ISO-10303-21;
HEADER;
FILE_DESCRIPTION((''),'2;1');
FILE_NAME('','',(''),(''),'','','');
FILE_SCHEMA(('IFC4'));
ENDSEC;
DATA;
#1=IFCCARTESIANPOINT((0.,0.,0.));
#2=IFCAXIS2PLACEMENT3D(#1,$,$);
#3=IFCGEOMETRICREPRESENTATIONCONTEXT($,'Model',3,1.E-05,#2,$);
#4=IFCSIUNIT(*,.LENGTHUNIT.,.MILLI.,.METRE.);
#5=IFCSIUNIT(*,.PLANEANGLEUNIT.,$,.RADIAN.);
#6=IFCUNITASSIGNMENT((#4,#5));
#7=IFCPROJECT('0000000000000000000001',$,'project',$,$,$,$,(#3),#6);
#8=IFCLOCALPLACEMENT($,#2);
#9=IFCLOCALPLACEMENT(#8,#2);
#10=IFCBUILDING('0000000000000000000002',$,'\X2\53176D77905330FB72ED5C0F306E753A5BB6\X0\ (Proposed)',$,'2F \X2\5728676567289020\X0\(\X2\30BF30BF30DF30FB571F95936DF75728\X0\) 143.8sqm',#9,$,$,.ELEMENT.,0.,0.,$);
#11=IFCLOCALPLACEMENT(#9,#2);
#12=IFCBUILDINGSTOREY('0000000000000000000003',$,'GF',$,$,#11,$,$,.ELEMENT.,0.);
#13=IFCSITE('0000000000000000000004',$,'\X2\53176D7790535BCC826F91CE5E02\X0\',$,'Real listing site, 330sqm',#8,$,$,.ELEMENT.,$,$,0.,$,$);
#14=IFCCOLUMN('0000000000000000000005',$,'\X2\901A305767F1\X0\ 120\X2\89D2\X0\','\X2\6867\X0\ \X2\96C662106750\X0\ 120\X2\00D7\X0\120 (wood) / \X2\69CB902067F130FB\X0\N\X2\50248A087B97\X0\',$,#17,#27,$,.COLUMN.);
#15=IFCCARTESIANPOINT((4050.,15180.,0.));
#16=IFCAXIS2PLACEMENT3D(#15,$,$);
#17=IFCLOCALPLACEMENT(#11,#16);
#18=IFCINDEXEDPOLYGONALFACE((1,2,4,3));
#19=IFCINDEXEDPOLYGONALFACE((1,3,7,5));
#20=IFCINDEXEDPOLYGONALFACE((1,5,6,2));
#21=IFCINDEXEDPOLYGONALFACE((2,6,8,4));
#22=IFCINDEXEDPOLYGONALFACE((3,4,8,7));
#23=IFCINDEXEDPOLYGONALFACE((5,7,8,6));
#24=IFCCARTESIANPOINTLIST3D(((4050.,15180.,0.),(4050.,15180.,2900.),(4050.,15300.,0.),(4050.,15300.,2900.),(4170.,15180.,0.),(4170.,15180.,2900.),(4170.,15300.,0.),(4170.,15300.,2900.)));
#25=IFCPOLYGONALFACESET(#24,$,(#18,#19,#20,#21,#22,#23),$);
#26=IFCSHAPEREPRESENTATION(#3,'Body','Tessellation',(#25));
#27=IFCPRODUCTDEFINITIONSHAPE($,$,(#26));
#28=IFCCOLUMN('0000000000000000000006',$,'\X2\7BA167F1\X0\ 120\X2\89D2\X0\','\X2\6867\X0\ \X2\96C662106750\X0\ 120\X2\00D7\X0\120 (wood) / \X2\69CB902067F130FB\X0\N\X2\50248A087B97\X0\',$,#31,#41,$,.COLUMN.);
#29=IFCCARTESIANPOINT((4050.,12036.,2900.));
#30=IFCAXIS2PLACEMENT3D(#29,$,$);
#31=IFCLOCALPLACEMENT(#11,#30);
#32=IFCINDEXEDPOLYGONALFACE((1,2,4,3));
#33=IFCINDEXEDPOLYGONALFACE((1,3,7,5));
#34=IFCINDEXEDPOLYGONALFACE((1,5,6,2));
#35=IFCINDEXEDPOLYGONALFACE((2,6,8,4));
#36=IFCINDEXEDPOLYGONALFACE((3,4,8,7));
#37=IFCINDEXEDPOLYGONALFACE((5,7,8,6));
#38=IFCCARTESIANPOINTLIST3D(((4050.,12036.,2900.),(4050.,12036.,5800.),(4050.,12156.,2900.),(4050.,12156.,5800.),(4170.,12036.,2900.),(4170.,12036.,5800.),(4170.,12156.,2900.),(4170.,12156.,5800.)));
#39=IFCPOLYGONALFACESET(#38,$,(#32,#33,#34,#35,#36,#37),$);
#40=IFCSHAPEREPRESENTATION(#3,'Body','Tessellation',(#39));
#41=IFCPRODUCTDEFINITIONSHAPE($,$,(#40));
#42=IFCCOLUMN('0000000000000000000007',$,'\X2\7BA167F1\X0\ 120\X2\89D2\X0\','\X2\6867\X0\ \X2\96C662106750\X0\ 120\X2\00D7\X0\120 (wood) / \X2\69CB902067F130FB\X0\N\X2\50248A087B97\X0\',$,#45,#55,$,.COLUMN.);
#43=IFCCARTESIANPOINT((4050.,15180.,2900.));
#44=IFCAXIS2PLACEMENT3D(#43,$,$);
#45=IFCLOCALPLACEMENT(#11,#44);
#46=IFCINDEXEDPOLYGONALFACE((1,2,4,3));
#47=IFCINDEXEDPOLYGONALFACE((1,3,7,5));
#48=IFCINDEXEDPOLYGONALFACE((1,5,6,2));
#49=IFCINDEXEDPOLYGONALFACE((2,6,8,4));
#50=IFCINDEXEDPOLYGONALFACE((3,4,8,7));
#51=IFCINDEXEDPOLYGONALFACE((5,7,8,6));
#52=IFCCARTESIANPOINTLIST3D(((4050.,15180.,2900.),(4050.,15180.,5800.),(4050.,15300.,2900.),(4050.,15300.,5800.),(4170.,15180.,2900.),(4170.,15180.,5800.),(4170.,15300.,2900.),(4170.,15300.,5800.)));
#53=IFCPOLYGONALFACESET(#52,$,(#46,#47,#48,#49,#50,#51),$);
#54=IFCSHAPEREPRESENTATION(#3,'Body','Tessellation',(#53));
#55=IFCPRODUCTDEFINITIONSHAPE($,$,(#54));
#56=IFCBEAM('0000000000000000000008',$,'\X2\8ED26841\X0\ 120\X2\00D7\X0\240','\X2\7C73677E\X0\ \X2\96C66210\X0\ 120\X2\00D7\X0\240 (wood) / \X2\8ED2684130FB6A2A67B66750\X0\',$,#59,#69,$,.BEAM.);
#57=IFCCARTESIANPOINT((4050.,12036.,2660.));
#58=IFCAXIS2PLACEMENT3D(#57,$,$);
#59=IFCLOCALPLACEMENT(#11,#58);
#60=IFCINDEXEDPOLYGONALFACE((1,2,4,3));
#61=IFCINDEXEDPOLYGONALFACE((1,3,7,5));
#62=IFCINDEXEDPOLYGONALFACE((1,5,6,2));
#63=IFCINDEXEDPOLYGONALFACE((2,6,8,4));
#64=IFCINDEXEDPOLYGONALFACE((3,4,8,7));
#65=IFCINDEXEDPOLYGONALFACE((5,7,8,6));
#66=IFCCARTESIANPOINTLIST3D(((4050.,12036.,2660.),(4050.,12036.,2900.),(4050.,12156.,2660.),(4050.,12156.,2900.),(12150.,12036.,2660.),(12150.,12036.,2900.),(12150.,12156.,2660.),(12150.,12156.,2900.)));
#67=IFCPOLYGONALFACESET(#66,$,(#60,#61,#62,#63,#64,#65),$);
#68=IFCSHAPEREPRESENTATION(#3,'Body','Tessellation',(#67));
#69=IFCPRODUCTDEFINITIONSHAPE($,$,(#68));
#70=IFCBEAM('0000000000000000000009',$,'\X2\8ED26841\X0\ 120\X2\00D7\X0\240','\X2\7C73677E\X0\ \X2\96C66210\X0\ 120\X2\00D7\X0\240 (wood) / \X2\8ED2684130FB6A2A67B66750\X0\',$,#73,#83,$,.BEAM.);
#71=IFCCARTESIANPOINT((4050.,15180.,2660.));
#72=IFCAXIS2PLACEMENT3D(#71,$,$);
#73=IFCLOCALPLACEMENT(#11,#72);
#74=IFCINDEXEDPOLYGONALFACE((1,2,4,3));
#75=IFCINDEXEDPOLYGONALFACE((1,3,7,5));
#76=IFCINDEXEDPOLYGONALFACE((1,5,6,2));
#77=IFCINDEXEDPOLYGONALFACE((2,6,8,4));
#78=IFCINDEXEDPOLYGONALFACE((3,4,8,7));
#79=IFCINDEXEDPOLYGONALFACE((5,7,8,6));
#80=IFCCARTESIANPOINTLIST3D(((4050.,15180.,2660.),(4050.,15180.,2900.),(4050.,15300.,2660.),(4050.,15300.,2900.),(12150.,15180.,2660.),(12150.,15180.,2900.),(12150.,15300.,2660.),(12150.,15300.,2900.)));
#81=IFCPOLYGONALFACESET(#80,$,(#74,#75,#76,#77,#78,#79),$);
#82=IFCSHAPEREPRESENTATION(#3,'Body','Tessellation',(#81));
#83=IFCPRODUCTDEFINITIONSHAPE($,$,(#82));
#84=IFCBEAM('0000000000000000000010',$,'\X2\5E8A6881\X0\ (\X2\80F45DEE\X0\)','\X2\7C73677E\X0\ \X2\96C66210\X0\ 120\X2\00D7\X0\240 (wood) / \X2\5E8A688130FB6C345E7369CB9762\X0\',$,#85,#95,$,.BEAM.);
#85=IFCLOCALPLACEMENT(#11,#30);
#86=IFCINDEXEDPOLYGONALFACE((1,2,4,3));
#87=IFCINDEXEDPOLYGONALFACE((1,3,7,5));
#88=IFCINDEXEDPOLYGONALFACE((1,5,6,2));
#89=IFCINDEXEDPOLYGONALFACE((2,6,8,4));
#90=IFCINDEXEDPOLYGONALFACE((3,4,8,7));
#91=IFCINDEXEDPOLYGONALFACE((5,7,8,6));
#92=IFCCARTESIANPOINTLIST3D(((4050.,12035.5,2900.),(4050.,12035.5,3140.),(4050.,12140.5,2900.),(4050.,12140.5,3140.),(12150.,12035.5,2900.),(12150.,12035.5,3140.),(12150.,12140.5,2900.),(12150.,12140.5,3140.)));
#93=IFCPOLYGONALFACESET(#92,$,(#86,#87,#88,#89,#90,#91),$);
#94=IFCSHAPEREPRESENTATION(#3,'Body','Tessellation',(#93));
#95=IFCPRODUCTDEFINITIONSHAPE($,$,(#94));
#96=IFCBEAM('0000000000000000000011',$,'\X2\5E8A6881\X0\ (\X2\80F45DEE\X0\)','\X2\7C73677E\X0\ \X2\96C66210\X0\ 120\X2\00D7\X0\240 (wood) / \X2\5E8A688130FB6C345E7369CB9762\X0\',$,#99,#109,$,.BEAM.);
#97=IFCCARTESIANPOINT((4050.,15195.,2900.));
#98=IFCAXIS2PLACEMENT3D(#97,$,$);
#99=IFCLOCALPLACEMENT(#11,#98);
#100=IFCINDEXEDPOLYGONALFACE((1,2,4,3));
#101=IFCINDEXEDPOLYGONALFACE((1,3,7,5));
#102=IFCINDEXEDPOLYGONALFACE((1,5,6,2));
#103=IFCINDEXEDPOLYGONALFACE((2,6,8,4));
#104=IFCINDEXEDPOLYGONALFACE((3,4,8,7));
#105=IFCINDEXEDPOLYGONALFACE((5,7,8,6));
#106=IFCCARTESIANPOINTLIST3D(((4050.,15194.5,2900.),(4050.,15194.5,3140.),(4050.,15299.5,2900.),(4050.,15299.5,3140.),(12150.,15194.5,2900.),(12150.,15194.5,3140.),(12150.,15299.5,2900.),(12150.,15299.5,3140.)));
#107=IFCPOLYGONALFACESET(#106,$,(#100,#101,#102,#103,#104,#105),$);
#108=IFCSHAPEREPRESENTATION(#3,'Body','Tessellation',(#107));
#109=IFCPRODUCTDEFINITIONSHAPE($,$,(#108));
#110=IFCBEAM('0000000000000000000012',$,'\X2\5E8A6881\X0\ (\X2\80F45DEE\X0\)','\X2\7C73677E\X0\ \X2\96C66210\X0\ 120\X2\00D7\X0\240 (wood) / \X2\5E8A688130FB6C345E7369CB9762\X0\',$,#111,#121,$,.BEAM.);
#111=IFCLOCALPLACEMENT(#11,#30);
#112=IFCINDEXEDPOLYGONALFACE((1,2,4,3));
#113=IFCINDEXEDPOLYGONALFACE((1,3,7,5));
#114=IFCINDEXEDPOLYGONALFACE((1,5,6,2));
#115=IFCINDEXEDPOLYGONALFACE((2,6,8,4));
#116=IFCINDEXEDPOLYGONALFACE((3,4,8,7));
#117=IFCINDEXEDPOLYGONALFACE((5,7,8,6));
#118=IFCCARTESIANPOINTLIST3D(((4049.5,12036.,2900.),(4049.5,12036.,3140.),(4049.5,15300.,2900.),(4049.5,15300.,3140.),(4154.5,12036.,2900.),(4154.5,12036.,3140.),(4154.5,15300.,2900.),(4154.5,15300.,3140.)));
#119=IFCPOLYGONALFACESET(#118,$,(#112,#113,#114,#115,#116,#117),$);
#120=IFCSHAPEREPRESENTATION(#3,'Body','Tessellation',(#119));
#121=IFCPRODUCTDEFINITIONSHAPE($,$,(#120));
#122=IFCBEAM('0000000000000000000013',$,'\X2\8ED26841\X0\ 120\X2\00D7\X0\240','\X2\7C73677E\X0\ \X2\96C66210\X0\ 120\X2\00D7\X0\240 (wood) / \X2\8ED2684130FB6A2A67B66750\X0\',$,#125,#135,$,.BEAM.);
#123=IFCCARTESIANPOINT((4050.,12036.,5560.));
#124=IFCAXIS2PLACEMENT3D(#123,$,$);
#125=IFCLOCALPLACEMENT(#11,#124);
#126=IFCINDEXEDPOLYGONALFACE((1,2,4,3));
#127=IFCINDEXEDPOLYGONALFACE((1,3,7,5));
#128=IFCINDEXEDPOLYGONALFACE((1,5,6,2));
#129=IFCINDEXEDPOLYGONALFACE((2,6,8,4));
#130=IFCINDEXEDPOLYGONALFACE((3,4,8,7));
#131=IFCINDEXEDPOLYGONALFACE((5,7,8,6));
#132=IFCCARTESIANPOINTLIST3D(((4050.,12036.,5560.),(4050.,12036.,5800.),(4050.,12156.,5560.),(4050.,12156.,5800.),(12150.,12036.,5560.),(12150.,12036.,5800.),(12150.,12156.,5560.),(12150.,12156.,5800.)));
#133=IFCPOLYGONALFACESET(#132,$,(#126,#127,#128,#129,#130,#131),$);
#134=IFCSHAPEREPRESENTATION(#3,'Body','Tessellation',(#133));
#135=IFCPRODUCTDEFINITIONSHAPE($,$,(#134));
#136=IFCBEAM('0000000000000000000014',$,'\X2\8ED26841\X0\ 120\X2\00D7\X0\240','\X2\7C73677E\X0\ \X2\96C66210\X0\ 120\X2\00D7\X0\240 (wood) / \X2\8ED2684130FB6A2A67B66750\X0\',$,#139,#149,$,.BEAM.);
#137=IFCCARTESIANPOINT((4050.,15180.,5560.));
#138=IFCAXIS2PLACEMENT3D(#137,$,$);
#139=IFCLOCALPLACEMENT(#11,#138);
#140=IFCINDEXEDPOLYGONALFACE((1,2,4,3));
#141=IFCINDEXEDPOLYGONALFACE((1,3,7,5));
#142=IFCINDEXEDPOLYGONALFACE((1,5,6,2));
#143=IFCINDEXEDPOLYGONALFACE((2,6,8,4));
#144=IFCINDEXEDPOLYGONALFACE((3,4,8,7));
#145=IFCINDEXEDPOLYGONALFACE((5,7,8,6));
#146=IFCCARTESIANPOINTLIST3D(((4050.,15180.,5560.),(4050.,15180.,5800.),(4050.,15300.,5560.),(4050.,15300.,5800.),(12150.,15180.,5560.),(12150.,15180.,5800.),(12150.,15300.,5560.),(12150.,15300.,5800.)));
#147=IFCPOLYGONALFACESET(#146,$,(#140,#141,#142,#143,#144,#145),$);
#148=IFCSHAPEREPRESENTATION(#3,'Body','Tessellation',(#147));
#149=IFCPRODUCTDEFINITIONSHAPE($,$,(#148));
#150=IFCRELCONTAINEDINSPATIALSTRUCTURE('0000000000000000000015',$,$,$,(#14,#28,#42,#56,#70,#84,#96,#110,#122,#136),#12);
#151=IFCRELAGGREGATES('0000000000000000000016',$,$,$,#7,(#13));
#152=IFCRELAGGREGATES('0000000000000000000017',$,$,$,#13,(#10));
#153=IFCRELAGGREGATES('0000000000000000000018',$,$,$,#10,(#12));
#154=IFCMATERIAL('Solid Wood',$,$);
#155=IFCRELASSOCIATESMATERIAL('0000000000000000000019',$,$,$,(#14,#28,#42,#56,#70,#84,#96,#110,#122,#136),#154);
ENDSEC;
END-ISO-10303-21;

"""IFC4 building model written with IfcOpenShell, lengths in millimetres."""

from ifc_helpers import new_model, si_unit, frame, frame_2d, origin, place, context, project, spatial, rectangle, extrude, material, element, save


model = new_model("IFC4")

# Units and contexts
model_context = context("Model", 3, precision=1e-05, world=origin())
ifc_project = project(units=[si_unit("LENGTHUNIT", "METRE", prefix="MILLI"), si_unit("PLANEANGLEUNIT", "RADIAN")], contexts=[model_context])

# Site, building, storey
site_placement = place(None, origin())
site = spatial("IfcSite", under=ifc_project, at=site_placement, Name="北海道富良野市", ObjectType="Real listing site, 330sqm", CompositionType="ELEMENT", RefElevation=0.0)
building_placement = place(site_placement, origin())
building = spatial("IfcBuilding", under=site, at=building_placement, Name="北海道・狭小の町家 (Proposed)", ObjectType="2F 在来木造(タタミ・土間混在) 143.8sqm", CompositionType="ELEMENT", ElevationOfRefHeight=0.0, ElevationOfTerrain=0.0)
storey_placement = place(building_placement, origin())
storey = spatial("IfcBuildingStorey", under=building, at=storey_placement, Name="GF", CompositionType="ELEMENT", Elevation=0.0)

# Columns
ifc_material_1 = material(Name="Solid Wood")
column_1_placement = place(storey_placement, frame((4050.0, 15180.0, 0.0)))
element("IfcColumn", 1, at=column_1_placement, inside=storey, material=ifc_material_1, Name="通し柱 120角", Description="桧 集成材 120×120 (wood) / 構造柱・N値計算", PredefinedType="COLUMN", context=model_context, shape_type="SweptSolid", body=[
    extrude(rectangle(XDim=120.0, YDim=120.0, at=frame_2d((60.0, 60.0))), frame((4050.0, 15180.0, 0.0)), (0.0, 0.0, 1.0), 2900.0),
])
column_2_placement = place(storey_placement, frame((4050.0, 12036.0, 2900.0)))
element("IfcColumn", 2, at=column_2_placement, inside=storey, material=ifc_material_1, Name="管柱 120角", Description="桧 集成材 120×120 (wood) / 構造柱・N値計算", PredefinedType="COLUMN", context=model_context, shape_type="SweptSolid", body=[
    extrude(rectangle(XDim=120.0, YDim=120.0, at=frame_2d((60.0, 60.0))), frame((4050.0, 12036.0, 2900.0)), (0.0, 0.0, 1.0), 2900.0),
])
column_3_placement = place(storey_placement, frame((4050.0, 15180.0, 2900.0)))
element("IfcColumn", 3, at=column_3_placement, inside=storey, material=ifc_material_1, Name="管柱 120角", Description="桧 集成材 120×120 (wood) / 構造柱・N値計算", PredefinedType="COLUMN", context=model_context, shape_type="SweptSolid", body=[
    extrude(rectangle(XDim=120.0, YDim=120.0, at=frame_2d((60.0, 60.0))), frame((4050.0, 15180.0, 2900.0)), (0.0, 0.0, 1.0), 2900.0),
])

# Beams
beam_1_placement = place(storey_placement, frame((4050.0, 12036.0, 2660.0)))
element("IfcBeam", 4, at=beam_1_placement, inside=storey, material=ifc_material_1, Name="軒桁 120×240", Description="米松 集成 120×240 (wood) / 軒桁・横架材", PredefinedType="BEAM", context=model_context, shape_type="SweptSolid", body=[
    extrude(rectangle(XDim=8100.0, YDim=120.0, at=frame_2d((4050.0, 60.0))), frame((4050.0, 12036.0, 2660.0)), (0.0, 0.0, 1.0), 240.0),
])
beam_2_placement = place(storey_placement, frame((4050.0, 15180.0, 2660.0)))
element("IfcBeam", 5, at=beam_2_placement, inside=storey, material=ifc_material_1, Name="軒桁 120×240", Description="米松 集成 120×240 (wood) / 軒桁・横架材", PredefinedType="BEAM", context=model_context, shape_type="SweptSolid", body=[
    extrude(rectangle(XDim=8100.0, YDim=120.0, at=frame_2d((4050.0, 60.0))), frame((4050.0, 15180.0, 2660.0)), (0.0, 0.0, 1.0), 240.0),
])
beam_3_placement = place(storey_placement, frame((4050.0, 12036.0, 2900.0)))
element("IfcBeam", 6, at=beam_3_placement, inside=storey, material=ifc_material_1, Name="床梁 (胴差)", Description="米松 集成 120×240 (wood) / 床梁・水平構面", PredefinedType="BEAM", context=model_context, shape_type="SweptSolid", body=[
    extrude(rectangle(XDim=8100.0, YDim=105.0, at=frame_2d((4050.0, 52.0))), frame((4050.0, 12036.0, 2900.0)), (0.0, 0.0, 1.0), 240.0),
])
beam_4_placement = place(storey_placement, frame((4050.0, 15195.0, 2900.0)))
element("IfcBeam", 7, at=beam_4_placement, inside=storey, material=ifc_material_1, Name="床梁 (胴差)", Description="米松 集成 120×240 (wood) / 床梁・水平構面", PredefinedType="BEAM", context=model_context, shape_type="SweptSolid", body=[
    extrude(rectangle(XDim=8100.0, YDim=105.0, at=frame_2d((4050.0, 52.0))), frame((4050.0, 15195.0, 2900.0)), (0.0, 0.0, 1.0), 240.0),
])
beam_5_placement = place(storey_placement, frame((4050.0, 12036.0, 2900.0)))
element("IfcBeam", 8, at=beam_5_placement, inside=storey, material=ifc_material_1, Name="床梁 (胴差)", Description="米松 集成 120×240 (wood) / 床梁・水平構面", PredefinedType="BEAM", context=model_context, shape_type="SweptSolid", body=[
    extrude(rectangle(XDim=105.0, YDim=3264.0, at=frame_2d((52.0, 1632.0))), frame((4050.0, 12036.0, 2900.0)), (0.0, 0.0, 1.0), 240.0),
])
beam_6_placement = place(storey_placement, frame((4050.0, 12036.0, 5560.0)))
element("IfcBeam", 9, at=beam_6_placement, inside=storey, material=ifc_material_1, Name="軒桁 120×240", Description="米松 集成 120×240 (wood) / 軒桁・横架材", PredefinedType="BEAM", context=model_context, shape_type="SweptSolid", body=[
    extrude(rectangle(XDim=8100.0, YDim=120.0, at=frame_2d((4050.0, 60.0))), frame((4050.0, 12036.0, 5560.0)), (0.0, 0.0, 1.0), 240.0),
])
beam_7_placement = place(storey_placement, frame((4050.0, 15180.0, 5560.0)))
element("IfcBeam", 10, at=beam_7_placement, inside=storey, material=ifc_material_1, Name="軒桁 120×240", Description="米松 集成 120×240 (wood) / 軒桁・横架材", PredefinedType="BEAM", context=model_context, shape_type="SweptSolid", body=[
    extrude(rectangle(XDim=8100.0, YDim=120.0, at=frame_2d((4050.0, 60.0))), frame((4050.0, 15180.0, 5560.0)), (0.0, 0.0, 1.0), 240.0),
])

save(model, "model.ifc")
